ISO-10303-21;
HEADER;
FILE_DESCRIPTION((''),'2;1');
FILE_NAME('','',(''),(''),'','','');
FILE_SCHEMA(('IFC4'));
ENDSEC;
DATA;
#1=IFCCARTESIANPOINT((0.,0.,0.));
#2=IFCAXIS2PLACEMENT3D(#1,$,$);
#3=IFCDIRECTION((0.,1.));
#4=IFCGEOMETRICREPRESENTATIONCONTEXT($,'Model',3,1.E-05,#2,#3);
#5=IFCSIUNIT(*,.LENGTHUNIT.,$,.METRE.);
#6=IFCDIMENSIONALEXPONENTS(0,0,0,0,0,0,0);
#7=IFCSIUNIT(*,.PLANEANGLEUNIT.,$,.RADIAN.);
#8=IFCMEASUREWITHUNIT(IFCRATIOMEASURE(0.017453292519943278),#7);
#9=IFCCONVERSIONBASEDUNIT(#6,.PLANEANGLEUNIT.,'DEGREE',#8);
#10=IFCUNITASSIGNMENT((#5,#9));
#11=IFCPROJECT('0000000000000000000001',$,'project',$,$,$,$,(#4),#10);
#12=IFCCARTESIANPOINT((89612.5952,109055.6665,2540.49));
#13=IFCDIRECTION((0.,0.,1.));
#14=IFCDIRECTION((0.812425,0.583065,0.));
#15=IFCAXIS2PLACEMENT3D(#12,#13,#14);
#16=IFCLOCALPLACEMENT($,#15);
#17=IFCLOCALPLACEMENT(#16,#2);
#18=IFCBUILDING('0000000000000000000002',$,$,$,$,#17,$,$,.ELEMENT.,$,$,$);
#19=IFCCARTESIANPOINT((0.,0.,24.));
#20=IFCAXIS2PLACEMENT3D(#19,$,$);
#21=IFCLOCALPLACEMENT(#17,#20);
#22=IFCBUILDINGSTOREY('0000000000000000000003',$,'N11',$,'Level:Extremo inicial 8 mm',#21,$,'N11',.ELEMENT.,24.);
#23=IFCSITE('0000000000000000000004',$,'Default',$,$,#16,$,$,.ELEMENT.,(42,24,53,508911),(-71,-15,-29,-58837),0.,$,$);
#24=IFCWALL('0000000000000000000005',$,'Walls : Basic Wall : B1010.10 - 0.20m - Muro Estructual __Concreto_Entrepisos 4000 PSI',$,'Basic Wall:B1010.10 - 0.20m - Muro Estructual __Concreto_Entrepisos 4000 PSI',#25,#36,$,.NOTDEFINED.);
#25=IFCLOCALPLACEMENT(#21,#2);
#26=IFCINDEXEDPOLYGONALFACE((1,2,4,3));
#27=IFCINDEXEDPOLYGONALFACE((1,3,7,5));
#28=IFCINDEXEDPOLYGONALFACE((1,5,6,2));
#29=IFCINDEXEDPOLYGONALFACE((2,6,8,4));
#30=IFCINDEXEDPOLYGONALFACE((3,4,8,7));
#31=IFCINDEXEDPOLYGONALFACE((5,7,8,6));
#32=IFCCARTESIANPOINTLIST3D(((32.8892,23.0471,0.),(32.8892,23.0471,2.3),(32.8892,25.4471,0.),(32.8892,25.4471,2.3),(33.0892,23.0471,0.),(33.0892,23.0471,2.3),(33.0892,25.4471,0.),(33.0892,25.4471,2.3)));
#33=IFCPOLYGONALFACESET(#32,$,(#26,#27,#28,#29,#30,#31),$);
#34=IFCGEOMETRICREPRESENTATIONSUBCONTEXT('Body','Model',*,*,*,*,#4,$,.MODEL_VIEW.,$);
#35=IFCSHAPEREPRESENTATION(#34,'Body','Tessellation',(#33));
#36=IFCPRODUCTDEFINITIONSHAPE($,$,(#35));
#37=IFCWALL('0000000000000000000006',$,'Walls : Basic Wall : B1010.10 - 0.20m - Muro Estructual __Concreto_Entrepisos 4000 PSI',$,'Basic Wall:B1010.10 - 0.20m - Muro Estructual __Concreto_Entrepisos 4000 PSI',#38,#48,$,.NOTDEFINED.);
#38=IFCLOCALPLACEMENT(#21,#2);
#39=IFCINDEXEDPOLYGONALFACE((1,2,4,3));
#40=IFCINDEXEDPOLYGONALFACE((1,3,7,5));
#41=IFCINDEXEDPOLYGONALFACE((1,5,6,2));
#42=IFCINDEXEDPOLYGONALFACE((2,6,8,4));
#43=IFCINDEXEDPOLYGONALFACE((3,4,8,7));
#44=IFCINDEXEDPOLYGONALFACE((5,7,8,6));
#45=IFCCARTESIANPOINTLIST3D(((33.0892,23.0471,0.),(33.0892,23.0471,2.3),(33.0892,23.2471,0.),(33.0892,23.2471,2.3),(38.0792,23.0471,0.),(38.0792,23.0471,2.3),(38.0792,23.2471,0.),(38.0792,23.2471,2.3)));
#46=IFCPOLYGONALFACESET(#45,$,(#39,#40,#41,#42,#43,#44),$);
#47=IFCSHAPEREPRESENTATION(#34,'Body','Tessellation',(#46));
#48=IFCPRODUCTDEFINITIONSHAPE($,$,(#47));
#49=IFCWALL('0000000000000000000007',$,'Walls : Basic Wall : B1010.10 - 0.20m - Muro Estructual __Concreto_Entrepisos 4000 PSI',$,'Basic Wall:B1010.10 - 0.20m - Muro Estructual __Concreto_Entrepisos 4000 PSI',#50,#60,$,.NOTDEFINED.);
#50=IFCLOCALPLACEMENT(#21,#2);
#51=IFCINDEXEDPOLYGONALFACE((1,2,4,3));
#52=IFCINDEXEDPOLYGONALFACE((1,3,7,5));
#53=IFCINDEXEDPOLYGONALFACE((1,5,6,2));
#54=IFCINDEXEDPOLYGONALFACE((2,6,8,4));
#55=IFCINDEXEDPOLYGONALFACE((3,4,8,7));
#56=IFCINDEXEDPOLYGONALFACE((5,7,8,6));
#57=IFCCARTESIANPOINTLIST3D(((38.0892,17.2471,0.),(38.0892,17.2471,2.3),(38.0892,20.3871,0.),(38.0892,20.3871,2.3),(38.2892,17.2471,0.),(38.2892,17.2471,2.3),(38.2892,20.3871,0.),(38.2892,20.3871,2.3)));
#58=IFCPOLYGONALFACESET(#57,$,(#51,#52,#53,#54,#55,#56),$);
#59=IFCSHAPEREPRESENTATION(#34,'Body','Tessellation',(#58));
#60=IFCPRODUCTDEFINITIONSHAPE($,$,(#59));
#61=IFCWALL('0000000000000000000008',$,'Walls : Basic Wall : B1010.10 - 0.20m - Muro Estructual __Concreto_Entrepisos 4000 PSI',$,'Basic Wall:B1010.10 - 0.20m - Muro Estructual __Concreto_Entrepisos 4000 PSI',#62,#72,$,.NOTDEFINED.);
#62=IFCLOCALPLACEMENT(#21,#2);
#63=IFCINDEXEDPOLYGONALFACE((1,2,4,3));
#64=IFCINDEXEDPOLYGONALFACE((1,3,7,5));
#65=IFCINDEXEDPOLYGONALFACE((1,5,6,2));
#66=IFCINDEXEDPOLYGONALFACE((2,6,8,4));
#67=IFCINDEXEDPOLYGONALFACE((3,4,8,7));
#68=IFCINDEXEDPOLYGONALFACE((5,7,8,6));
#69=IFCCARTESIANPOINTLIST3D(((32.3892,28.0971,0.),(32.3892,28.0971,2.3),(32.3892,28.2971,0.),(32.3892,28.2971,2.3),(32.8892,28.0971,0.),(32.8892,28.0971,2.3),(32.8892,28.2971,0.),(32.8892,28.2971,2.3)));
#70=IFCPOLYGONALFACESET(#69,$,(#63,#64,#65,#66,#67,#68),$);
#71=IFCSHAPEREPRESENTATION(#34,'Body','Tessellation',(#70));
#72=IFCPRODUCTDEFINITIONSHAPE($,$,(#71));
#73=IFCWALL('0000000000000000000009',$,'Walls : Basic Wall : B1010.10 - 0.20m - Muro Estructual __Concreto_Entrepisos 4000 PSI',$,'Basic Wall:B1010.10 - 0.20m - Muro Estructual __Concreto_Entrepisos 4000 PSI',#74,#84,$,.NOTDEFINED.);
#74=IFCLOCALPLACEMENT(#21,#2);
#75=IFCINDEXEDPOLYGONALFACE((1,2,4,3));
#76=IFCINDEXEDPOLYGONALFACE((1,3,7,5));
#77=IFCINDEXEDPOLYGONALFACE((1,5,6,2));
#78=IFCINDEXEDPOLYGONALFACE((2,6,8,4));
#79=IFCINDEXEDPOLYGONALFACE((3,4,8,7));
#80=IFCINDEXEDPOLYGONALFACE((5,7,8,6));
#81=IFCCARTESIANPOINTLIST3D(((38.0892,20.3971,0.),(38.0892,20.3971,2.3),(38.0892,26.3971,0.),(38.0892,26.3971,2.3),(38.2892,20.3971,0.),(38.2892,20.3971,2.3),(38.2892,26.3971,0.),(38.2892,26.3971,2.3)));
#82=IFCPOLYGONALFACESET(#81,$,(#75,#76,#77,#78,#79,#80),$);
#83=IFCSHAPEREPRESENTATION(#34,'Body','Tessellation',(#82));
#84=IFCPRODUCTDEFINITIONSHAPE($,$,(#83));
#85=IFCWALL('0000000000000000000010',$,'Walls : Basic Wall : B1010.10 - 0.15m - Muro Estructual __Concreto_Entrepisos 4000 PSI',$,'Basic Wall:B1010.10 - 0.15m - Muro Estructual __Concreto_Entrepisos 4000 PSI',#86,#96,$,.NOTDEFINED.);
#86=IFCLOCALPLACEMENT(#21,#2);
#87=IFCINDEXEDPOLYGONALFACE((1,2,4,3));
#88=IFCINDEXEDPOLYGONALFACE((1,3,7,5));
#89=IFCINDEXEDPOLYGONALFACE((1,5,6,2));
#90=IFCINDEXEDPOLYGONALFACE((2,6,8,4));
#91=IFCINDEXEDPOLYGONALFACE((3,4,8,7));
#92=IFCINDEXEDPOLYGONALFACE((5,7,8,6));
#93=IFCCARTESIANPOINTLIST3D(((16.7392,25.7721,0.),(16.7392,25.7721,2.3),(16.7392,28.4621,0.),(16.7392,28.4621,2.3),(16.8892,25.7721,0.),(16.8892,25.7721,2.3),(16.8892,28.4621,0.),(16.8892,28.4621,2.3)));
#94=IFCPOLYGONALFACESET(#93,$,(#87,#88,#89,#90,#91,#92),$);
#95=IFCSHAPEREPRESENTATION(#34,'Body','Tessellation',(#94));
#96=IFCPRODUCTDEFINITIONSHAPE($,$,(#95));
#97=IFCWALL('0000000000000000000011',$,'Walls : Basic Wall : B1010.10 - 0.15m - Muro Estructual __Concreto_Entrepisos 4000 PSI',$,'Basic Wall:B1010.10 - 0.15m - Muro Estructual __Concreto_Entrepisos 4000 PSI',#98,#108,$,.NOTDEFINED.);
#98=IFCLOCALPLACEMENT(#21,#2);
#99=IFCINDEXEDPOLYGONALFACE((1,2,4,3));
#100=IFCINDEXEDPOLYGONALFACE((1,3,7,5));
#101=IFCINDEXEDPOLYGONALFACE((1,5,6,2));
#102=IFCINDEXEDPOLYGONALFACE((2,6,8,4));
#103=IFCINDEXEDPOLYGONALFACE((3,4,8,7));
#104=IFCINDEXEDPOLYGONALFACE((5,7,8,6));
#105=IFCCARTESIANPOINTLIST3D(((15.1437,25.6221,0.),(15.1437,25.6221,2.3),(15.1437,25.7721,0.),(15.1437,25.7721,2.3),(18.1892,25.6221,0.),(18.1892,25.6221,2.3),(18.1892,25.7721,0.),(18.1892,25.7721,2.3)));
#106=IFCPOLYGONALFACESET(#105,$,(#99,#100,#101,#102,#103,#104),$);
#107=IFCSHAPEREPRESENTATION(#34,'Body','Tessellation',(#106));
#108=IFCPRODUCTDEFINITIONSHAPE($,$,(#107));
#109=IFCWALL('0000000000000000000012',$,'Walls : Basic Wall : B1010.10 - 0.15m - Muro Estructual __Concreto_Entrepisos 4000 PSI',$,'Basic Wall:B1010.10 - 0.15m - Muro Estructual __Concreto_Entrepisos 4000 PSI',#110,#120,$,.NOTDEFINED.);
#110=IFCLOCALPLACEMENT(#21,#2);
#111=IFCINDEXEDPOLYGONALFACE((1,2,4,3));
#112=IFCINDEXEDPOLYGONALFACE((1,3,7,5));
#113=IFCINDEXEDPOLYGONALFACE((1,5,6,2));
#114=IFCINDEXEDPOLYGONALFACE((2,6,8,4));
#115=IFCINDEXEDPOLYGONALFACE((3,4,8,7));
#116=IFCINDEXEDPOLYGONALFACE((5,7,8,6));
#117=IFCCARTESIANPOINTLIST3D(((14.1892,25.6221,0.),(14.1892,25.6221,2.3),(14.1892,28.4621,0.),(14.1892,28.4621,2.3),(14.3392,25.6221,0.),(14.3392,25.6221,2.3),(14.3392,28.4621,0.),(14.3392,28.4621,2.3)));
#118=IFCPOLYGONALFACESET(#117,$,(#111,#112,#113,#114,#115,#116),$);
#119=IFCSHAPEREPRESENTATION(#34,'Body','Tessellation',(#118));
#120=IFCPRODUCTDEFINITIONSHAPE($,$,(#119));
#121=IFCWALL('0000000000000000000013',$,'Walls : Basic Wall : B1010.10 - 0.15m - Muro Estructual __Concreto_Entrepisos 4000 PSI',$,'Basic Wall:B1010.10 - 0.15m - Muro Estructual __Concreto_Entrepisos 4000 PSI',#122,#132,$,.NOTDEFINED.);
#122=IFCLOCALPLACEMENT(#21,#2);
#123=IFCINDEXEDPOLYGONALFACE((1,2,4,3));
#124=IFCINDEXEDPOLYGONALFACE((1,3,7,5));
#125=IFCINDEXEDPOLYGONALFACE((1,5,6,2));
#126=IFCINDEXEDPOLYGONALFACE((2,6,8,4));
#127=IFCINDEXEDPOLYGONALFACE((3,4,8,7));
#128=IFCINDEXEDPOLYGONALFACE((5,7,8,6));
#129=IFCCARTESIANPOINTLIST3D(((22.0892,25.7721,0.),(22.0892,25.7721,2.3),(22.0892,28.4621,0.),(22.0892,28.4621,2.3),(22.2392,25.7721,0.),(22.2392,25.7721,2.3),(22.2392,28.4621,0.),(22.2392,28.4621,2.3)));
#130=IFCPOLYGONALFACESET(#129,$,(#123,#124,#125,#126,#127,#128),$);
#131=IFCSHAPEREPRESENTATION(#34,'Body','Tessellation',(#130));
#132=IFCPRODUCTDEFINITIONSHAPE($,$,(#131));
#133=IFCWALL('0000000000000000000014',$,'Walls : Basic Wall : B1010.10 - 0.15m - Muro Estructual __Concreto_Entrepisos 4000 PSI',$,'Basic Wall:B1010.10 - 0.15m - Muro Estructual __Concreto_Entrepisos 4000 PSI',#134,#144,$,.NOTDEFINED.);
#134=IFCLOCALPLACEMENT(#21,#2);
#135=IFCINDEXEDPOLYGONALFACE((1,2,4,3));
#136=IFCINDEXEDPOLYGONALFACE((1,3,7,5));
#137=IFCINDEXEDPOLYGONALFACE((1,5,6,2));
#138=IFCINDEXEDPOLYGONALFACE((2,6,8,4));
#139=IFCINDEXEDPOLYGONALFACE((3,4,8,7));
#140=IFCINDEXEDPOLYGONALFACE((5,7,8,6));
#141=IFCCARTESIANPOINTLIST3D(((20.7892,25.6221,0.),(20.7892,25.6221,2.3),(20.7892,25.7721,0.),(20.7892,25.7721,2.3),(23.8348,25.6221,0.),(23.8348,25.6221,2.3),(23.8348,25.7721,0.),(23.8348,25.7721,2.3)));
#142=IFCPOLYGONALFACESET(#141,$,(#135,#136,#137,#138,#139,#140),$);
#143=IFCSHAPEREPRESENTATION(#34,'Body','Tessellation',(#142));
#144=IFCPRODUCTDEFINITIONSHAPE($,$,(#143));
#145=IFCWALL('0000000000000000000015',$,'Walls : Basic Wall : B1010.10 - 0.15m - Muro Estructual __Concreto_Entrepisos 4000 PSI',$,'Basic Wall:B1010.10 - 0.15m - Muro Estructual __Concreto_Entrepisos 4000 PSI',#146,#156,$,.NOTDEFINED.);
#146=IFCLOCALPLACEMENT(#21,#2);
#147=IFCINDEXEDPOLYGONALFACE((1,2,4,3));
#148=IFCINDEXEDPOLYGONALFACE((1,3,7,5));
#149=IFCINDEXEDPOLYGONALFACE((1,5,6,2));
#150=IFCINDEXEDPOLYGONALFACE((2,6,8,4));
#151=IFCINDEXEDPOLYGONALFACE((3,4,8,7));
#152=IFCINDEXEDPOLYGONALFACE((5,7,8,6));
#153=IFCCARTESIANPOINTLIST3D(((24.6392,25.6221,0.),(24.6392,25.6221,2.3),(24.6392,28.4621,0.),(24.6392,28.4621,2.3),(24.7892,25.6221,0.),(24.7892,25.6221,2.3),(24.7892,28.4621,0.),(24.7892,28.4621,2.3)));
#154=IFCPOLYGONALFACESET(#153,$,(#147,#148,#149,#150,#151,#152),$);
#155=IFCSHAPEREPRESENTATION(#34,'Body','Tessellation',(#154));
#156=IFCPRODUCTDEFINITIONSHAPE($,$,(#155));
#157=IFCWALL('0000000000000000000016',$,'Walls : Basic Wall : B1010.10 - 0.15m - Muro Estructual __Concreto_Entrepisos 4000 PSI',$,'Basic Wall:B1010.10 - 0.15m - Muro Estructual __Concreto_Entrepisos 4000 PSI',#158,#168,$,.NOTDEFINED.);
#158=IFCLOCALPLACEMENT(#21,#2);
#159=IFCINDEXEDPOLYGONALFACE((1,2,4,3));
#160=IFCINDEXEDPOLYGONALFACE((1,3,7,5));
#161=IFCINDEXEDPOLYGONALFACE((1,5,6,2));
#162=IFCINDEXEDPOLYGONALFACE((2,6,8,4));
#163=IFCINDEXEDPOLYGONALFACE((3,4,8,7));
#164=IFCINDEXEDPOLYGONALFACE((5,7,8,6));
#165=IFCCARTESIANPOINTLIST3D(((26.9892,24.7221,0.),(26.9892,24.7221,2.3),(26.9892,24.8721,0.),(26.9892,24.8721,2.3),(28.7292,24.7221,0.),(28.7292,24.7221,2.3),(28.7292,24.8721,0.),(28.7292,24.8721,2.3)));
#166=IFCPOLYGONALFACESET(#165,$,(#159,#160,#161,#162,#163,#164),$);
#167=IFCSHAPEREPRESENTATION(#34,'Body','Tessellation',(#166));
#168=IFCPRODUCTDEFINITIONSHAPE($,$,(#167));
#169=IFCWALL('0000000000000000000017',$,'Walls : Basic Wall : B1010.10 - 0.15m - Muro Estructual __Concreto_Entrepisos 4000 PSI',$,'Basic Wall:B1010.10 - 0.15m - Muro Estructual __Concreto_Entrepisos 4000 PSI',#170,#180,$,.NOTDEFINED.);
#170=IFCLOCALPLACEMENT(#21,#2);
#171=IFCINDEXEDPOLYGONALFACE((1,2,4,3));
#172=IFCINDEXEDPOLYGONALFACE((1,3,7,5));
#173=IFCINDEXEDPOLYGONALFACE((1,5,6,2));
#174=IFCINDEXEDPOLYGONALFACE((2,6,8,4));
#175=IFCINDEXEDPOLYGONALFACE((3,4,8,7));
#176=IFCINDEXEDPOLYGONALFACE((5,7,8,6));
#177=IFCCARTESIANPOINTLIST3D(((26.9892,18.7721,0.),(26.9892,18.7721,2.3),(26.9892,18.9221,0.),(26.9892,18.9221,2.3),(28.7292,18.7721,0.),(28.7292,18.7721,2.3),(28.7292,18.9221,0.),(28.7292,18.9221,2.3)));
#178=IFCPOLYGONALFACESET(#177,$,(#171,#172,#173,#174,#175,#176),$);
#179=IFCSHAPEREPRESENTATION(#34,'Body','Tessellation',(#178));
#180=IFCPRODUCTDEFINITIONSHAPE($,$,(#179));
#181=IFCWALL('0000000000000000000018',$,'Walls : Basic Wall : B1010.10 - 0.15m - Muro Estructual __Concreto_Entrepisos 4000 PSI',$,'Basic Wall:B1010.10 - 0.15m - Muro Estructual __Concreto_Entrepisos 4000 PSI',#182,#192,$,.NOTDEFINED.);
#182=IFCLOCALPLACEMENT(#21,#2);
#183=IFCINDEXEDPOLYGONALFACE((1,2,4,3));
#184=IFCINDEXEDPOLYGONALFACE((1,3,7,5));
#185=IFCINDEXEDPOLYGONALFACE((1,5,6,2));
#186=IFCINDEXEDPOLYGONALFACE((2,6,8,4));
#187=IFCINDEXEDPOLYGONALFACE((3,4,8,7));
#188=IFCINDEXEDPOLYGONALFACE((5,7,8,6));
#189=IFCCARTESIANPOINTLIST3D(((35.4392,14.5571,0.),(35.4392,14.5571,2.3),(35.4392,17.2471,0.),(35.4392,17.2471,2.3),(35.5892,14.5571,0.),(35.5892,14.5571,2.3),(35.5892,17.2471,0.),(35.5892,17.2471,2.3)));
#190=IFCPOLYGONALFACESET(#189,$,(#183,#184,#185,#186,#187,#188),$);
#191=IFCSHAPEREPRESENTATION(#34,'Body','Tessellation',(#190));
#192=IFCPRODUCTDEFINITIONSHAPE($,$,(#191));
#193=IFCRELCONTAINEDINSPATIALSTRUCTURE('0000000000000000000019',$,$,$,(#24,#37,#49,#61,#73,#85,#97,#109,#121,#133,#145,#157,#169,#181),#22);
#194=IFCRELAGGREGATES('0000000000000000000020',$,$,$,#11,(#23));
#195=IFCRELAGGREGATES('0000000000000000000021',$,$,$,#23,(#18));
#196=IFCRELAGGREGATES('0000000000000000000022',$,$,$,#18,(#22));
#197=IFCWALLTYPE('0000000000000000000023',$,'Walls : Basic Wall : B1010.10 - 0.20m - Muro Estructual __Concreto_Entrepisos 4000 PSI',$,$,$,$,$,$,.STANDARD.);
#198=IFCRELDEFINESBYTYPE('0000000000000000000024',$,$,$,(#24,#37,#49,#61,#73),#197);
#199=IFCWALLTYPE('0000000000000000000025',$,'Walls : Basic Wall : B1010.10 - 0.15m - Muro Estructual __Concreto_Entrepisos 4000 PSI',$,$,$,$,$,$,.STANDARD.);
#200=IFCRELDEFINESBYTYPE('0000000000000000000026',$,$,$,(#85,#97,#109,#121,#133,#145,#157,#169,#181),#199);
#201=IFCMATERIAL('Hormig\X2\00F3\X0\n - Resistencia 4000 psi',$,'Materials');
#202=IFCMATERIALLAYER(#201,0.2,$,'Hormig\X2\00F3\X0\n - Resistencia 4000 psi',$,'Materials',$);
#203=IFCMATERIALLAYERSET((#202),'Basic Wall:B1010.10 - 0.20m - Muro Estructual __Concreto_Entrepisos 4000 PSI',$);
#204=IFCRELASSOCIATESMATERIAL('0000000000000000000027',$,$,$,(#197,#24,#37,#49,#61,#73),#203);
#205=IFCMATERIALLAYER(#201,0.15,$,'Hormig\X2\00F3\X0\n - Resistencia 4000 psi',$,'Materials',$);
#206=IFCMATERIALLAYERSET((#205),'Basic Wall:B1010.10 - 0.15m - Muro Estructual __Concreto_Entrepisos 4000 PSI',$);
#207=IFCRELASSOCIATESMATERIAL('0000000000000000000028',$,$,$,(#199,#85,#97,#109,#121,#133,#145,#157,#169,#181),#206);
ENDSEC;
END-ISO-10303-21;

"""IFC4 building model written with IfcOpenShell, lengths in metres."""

from ifc_helpers import new_model, entity, si_unit, converted_unit, direction, frame, frame_2d, origin, place, context, subcontext, project, spatial, rectangle, extrude, material, layer, layer_set, layer_usage, type_object, element, save


model = new_model("IFC4")

# Units and contexts
model_context = context("Model", 3, precision=1e-05, world=origin(), true_north=direction((0.0, 1.0)))
body_context = subcontext(model_context, "Body", "Model", "MODEL_VIEW")
ifc_project = project(units=[si_unit("LENGTHUNIT", "METRE"), converted_unit("PLANEANGLEUNIT", "DEGREE", entity("IfcRatioMeasure", 0.017453292519943278), si_unit("PLANEANGLEUNIT", "RADIAN"), dimensions=[0, 0, 0, 0, 0, 0, 0])], contexts=[model_context])

# Site, building, storey
site_placement = place(None, frame((89612.5952, 109055.6665, 2540.49), z_axis=(0.0, 0.0, 1.0), x_axis=(0.812425, 0.583065, 0.0)))
site = spatial("IfcSite", under=ifc_project, at=site_placement, Name="Default", CompositionType="ELEMENT", RefLatitude=(42, 24, 53, 508911), RefLongitude=(-71, -15, -29, -58837), RefElevation=0.0)
building_placement = place(site_placement, origin())
building = spatial("IfcBuilding", under=site, at=building_placement, CompositionType="ELEMENT")
storey_placement = place(building_placement, frame((0.0, 0.0, 24.0)))
storey = spatial("IfcBuildingStorey", under=building, at=storey_placement, Name="N11", ObjectType="Level:Extremo inicial 8 mm", LongName="N11", CompositionType="ELEMENT", Elevation=24.0)

# Walls
ifc_material = material(Name="Hormigón - Resistencia 4000 psi", Category="Materials")
ifc_layer_1 = layer(ifc_material, 0.2, Name="Hormigón - Resistencia 4000 psi", Category="Materials")
ifc_layer_set_1 = layer_set([ifc_layer_1], Name="Basic Wall:B1010.10 - 0.20m - Muro Estructual __Concreto_Entrepisos 4000 PSI")
wall_type_1 = type_object("IfcWallType", Name="Walls : Basic Wall : B1010.10 - 0.20m - Muro Estructual __Concreto_Entrepisos 4000 PSI", PredefinedType="STANDARD", material=ifc_layer_set_1)
ifc_layer_usage_1 = layer_usage(ifc_layer_set_1, "AXIS2", "POSITIVE", -0.1)
wall_1_placement = place(storey_placement, frame((32.9892, 25.4471, 0.0), z_axis=(0.0, 0.0, 1.0), x_axis=(0.0, -1.0, 0.0)))
element("IfcWall", 1, at=wall_1_placement, inside=storey, type_object=wall_type_1, material=ifc_layer_usage_1, Name="Walls : Basic Wall : B1010.10 - 0.20m - Muro Estructual __Concreto_Entrepisos 4000 PSI", ObjectType="Basic Wall:B1010.10 - 0.20m - Muro Estructual __Concreto_Entrepisos 4000 PSI", PredefinedType="NOTDEFINED", context=body_context, shape_type="SweptSolid", body=[
    extrude(rectangle(XDim=2.4, YDim=0.2, at=frame_2d((1.2, 0.0), x_axis=(-1.0, 0.0))), origin(), (0.0, 0.0, 1.0), 2.3),
])
ifc_layer_usage_2 = layer_usage(ifc_layer_set_1, "AXIS2", "POSITIVE", -0.1)
wall_2_placement = place(storey_placement, frame((33.0892, 23.1471, 0.0)))
element("IfcWall", 2, at=wall_2_placement, inside=storey, type_object=wall_type_1, material=ifc_layer_usage_2, Name="Walls : Basic Wall : B1010.10 - 0.20m - Muro Estructual __Concreto_Entrepisos 4000 PSI", ObjectType="Basic Wall:B1010.10 - 0.20m - Muro Estructual __Concreto_Entrepisos 4000 PSI", PredefinedType="NOTDEFINED", context=body_context, shape_type="SweptSolid", body=[
    extrude(rectangle(XDim=4.99, YDim=0.2, at=frame_2d((2.495, 0.0), x_axis=(-1.0, 0.0))), origin(), (0.0, 0.0, 1.0), 2.3),
])
ifc_layer_usage_3 = layer_usage(ifc_layer_set_1, "AXIS2", "POSITIVE", -0.1)
wall_3_placement = place(storey_placement, frame((38.1892, 17.2471, 0.0), z_axis=(0.0, 0.0, 1.0), x_axis=(0.0, 1.0, 0.0)))
element("IfcWall", 3, at=wall_3_placement, inside=storey, type_object=wall_type_1, material=ifc_layer_usage_3, Name="Walls : Basic Wall : B1010.10 - 0.20m - Muro Estructual __Concreto_Entrepisos 4000 PSI", ObjectType="Basic Wall:B1010.10 - 0.20m - Muro Estructual __Concreto_Entrepisos 4000 PSI", PredefinedType="NOTDEFINED", context=body_context, shape_type="SweptSolid", body=[
    extrude(rectangle(XDim=3.14, YDim=0.2, at=frame_2d((1.57, 0.0), x_axis=(-1.0, 0.0))), origin(), (0.0, 0.0, 1.0), 2.3),
])
ifc_layer_usage_4 = layer_usage(ifc_layer_set_1, "AXIS2", "POSITIVE", -0.1)
wall_4_placement = place(storey_placement, frame((32.3892, 28.1971, 0.0)))
element("IfcWall", 4, at=wall_4_placement, inside=storey, type_object=wall_type_1, material=ifc_layer_usage_4, Name="Walls : Basic Wall : B1010.10 - 0.20m - Muro Estructual __Concreto_Entrepisos 4000 PSI", ObjectType="Basic Wall:B1010.10 - 0.20m - Muro Estructual __Concreto_Entrepisos 4000 PSI", PredefinedType="NOTDEFINED", context=body_context, shape_type="SweptSolid", body=[
    extrude(rectangle(XDim=0.5, YDim=0.2, at=frame_2d((0.25, 0.0), x_axis=(-1.0, 0.0))), origin(), (0.0, 0.0, 1.0), 2.3),
])
ifc_layer_usage_5 = layer_usage(ifc_layer_set_1, "AXIS2", "POSITIVE", -0.1)
wall_5_placement = place(storey_placement, frame((38.1892, 20.3971, 0.0), z_axis=(0.0, 0.0, 1.0), x_axis=(0.0, 1.0, 0.0)))
element("IfcWall", 5, at=wall_5_placement, inside=storey, type_object=wall_type_1, material=ifc_layer_usage_5, Name="Walls : Basic Wall : B1010.10 - 0.20m - Muro Estructual __Concreto_Entrepisos 4000 PSI", ObjectType="Basic Wall:B1010.10 - 0.20m - Muro Estructual __Concreto_Entrepisos 4000 PSI", PredefinedType="NOTDEFINED", context=body_context, shape_type="SweptSolid", body=[
    extrude(rectangle(XDim=6.0, YDim=0.2, at=frame_2d((3.0, 0.0), x_axis=(-1.0, 0.0))), origin(), (0.0, 0.0, 1.0), 2.3),
])
ifc_layer_2 = layer(ifc_material, 0.15, Name="Hormigón - Resistencia 4000 psi", Category="Materials")
ifc_layer_set_2 = layer_set([ifc_layer_2], Name="Basic Wall:B1010.10 - 0.15m - Muro Estructual __Concreto_Entrepisos 4000 PSI")
ifc_layer_usage_6 = layer_usage(ifc_layer_set_2, "AXIS2", "POSITIVE", -0.075)
wall_type_2 = type_object("IfcWallType", Name="Walls : Basic Wall : B1010.10 - 0.15m - Muro Estructual __Concreto_Entrepisos 4000 PSI", PredefinedType="STANDARD", material=ifc_layer_set_2)
wall_6_placement = place(storey_placement, frame((16.8142, 28.4621, 0.0), z_axis=(0.0, 0.0, 1.0), x_axis=(0.0, -1.0, 0.0)))
element("IfcWall", 6, at=wall_6_placement, inside=storey, type_object=wall_type_2, material=ifc_layer_usage_6, Name="Walls : Basic Wall : B1010.10 - 0.15m - Muro Estructual __Concreto_Entrepisos 4000 PSI", ObjectType="Basic Wall:B1010.10 - 0.15m - Muro Estructual __Concreto_Entrepisos 4000 PSI", PredefinedType="NOTDEFINED", context=body_context, shape_type="SweptSolid", body=[
    extrude(rectangle(XDim=2.69, YDim=0.15, at=frame_2d((1.345, 0.0), x_axis=(-1.0, 0.0))), origin(), (0.0, 0.0, 1.0), 2.3),
])
ifc_layer_usage_7 = layer_usage(ifc_layer_set_2, "AXIS2", "POSITIVE", -0.075)
wall_7_placement = place(storey_placement, frame((18.1892, 25.6971, 0.0), z_axis=(0.0, 0.0, 1.0), x_axis=(-1.0, 0.0, 0.0)))
element("IfcWall", 7, at=wall_7_placement, inside=storey, type_object=wall_type_2, material=ifc_layer_usage_7, Name="Walls : Basic Wall : B1010.10 - 0.15m - Muro Estructual __Concreto_Entrepisos 4000 PSI", ObjectType="Basic Wall:B1010.10 - 0.15m - Muro Estructual __Concreto_Entrepisos 4000 PSI", PredefinedType="NOTDEFINED", context=body_context, shape_type="SweptSolid", body=[
    extrude(rectangle(XDim=3.0455, YDim=0.15, at=frame_2d((1.5228, 0.0), x_axis=(-1.0, 0.0))), origin(), (0.0, 0.0, 1.0), 2.3),
])
ifc_layer_usage_8 = layer_usage(ifc_layer_set_2, "AXIS2", "POSITIVE", -0.075)
wall_8_placement = place(storey_placement, frame((14.2642, 28.4621, 0.0), z_axis=(0.0, 0.0, 1.0), x_axis=(0.0, -1.0, 0.0)))
element("IfcWall", 8, at=wall_8_placement, inside=storey, type_object=wall_type_2, material=ifc_layer_usage_8, Name="Walls : Basic Wall : B1010.10 - 0.15m - Muro Estructual __Concreto_Entrepisos 4000 PSI", ObjectType="Basic Wall:B1010.10 - 0.15m - Muro Estructual __Concreto_Entrepisos 4000 PSI", PredefinedType="NOTDEFINED", context=body_context, shape_type="SweptSolid", body=[
    extrude(rectangle(XDim=2.84, YDim=0.15, at=frame_2d((1.42, 0.0), x_axis=(-1.0, 0.0))), origin(), (0.0, 0.0, 1.0), 2.3),
])
ifc_layer_usage_9 = layer_usage(ifc_layer_set_2, "AXIS2", "NEGATIVE", 0.075)
wall_9_placement = place(storey_placement, frame((22.1642, 28.4621, 0.0), z_axis=(0.0, 0.0, 1.0), x_axis=(0.0, -1.0, 0.0)))
element("IfcWall", 9, at=wall_9_placement, inside=storey, type_object=wall_type_2, material=ifc_layer_usage_9, Name="Walls : Basic Wall : B1010.10 - 0.15m - Muro Estructual __Concreto_Entrepisos 4000 PSI", ObjectType="Basic Wall:B1010.10 - 0.15m - Muro Estructual __Concreto_Entrepisos 4000 PSI", PredefinedType="NOTDEFINED", context=body_context, shape_type="SweptSolid", body=[
    extrude(rectangle(XDim=2.69, YDim=0.15, at=frame_2d((1.345, 0.0), x_axis=(-1.0, 0.0))), origin(), (0.0, 0.0, 1.0), 2.3),
])
ifc_layer_usage_10 = layer_usage(ifc_layer_set_2, "AXIS2", "NEGATIVE", 0.075)
wall_10_placement = place(storey_placement, frame((20.7892, 25.6971, 0.0)))
element("IfcWall", 10, at=wall_10_placement, inside=storey, type_object=wall_type_2, material=ifc_layer_usage_10, Name="Walls : Basic Wall : B1010.10 - 0.15m - Muro Estructual __Concreto_Entrepisos 4000 PSI", ObjectType="Basic Wall:B1010.10 - 0.15m - Muro Estructual __Concreto_Entrepisos 4000 PSI", PredefinedType="NOTDEFINED", context=body_context, shape_type="SweptSolid", body=[
    extrude(rectangle(XDim=3.0455, YDim=0.15, at=frame_2d((1.5228, 0.0), x_axis=(-1.0, 0.0))), origin(), (0.0, 0.0, 1.0), 2.3),
])
ifc_layer_usage_11 = layer_usage(ifc_layer_set_2, "AXIS2", "NEGATIVE", 0.075)
wall_11_placement = place(storey_placement, frame((24.7142, 28.4621, 0.0), z_axis=(0.0, 0.0, 1.0), x_axis=(0.0, -1.0, 0.0)))
element("IfcWall", 11, at=wall_11_placement, inside=storey, type_object=wall_type_2, material=ifc_layer_usage_11, Name="Walls : Basic Wall : B1010.10 - 0.15m - Muro Estructual __Concreto_Entrepisos 4000 PSI", ObjectType="Basic Wall:B1010.10 - 0.15m - Muro Estructual __Concreto_Entrepisos 4000 PSI", PredefinedType="NOTDEFINED", context=body_context, shape_type="SweptSolid", body=[
    extrude(rectangle(XDim=2.84, YDim=0.15, at=frame_2d((1.42, 0.0), x_axis=(-1.0, 0.0))), origin(), (0.0, 0.0, 1.0), 2.3),
])
ifc_layer_usage_12 = layer_usage(ifc_layer_set_2, "AXIS2", "NEGATIVE", 0.075)
wall_12_placement = place(storey_placement, frame((26.9892, 24.7971, 0.0)))
element("IfcWall", 12, at=wall_12_placement, inside=storey, type_object=wall_type_2, material=ifc_layer_usage_12, Name="Walls : Basic Wall : B1010.10 - 0.15m - Muro Estructual __Concreto_Entrepisos 4000 PSI", ObjectType="Basic Wall:B1010.10 - 0.15m - Muro Estructual __Concreto_Entrepisos 4000 PSI", PredefinedType="NOTDEFINED", context=body_context, shape_type="SweptSolid", body=[
    extrude(rectangle(XDim=1.74, YDim=0.15, at=frame_2d((0.87, 0.0), x_axis=(-1.0, 0.0))), origin(), (0.0, 0.0, 1.0), 2.3),
])
ifc_layer_usage_13 = layer_usage(ifc_layer_set_2, "AXIS2", "POSITIVE", -0.075)
wall_13_placement = place(storey_placement, frame((26.9892, 18.8471, 0.0)))
element("IfcWall", 13, at=wall_13_placement, inside=storey, type_object=wall_type_2, material=ifc_layer_usage_13, Name="Walls : Basic Wall : B1010.10 - 0.15m - Muro Estructual __Concreto_Entrepisos 4000 PSI", ObjectType="Basic Wall:B1010.10 - 0.15m - Muro Estructual __Concreto_Entrepisos 4000 PSI", PredefinedType="NOTDEFINED", context=body_context, shape_type="SweptSolid", body=[
    extrude(rectangle(XDim=1.74, YDim=0.15, at=frame_2d((0.87, 0.0), x_axis=(-1.0, 0.0))), origin(), (0.0, 0.0, 1.0), 2.3),
])
ifc_layer_usage_14 = layer_usage(ifc_layer_set_2, "AXIS2", "NEGATIVE", 0.075)
wall_14_placement = place(storey_placement, frame((35.5142, 14.5571, 0.0), z_axis=(0.0, 0.0, 1.0), x_axis=(0.0, 1.0, 0.0)))
element("IfcWall", 14, at=wall_14_placement, inside=storey, type_object=wall_type_2, material=ifc_layer_usage_14, Name="Walls : Basic Wall : B1010.10 - 0.15m - Muro Estructual __Concreto_Entrepisos 4000 PSI", ObjectType="Basic Wall:B1010.10 - 0.15m - Muro Estructual __Concreto_Entrepisos 4000 PSI", PredefinedType="NOTDEFINED", context=body_context, shape_type="SweptSolid", body=[
    extrude(rectangle(XDim=2.69, YDim=0.15, at=frame_2d((1.345, 0.0), x_axis=(-1.0, 0.0))), origin(), (0.0, 0.0, 1.0), 2.3),
])

save(model, "model.ifc")
